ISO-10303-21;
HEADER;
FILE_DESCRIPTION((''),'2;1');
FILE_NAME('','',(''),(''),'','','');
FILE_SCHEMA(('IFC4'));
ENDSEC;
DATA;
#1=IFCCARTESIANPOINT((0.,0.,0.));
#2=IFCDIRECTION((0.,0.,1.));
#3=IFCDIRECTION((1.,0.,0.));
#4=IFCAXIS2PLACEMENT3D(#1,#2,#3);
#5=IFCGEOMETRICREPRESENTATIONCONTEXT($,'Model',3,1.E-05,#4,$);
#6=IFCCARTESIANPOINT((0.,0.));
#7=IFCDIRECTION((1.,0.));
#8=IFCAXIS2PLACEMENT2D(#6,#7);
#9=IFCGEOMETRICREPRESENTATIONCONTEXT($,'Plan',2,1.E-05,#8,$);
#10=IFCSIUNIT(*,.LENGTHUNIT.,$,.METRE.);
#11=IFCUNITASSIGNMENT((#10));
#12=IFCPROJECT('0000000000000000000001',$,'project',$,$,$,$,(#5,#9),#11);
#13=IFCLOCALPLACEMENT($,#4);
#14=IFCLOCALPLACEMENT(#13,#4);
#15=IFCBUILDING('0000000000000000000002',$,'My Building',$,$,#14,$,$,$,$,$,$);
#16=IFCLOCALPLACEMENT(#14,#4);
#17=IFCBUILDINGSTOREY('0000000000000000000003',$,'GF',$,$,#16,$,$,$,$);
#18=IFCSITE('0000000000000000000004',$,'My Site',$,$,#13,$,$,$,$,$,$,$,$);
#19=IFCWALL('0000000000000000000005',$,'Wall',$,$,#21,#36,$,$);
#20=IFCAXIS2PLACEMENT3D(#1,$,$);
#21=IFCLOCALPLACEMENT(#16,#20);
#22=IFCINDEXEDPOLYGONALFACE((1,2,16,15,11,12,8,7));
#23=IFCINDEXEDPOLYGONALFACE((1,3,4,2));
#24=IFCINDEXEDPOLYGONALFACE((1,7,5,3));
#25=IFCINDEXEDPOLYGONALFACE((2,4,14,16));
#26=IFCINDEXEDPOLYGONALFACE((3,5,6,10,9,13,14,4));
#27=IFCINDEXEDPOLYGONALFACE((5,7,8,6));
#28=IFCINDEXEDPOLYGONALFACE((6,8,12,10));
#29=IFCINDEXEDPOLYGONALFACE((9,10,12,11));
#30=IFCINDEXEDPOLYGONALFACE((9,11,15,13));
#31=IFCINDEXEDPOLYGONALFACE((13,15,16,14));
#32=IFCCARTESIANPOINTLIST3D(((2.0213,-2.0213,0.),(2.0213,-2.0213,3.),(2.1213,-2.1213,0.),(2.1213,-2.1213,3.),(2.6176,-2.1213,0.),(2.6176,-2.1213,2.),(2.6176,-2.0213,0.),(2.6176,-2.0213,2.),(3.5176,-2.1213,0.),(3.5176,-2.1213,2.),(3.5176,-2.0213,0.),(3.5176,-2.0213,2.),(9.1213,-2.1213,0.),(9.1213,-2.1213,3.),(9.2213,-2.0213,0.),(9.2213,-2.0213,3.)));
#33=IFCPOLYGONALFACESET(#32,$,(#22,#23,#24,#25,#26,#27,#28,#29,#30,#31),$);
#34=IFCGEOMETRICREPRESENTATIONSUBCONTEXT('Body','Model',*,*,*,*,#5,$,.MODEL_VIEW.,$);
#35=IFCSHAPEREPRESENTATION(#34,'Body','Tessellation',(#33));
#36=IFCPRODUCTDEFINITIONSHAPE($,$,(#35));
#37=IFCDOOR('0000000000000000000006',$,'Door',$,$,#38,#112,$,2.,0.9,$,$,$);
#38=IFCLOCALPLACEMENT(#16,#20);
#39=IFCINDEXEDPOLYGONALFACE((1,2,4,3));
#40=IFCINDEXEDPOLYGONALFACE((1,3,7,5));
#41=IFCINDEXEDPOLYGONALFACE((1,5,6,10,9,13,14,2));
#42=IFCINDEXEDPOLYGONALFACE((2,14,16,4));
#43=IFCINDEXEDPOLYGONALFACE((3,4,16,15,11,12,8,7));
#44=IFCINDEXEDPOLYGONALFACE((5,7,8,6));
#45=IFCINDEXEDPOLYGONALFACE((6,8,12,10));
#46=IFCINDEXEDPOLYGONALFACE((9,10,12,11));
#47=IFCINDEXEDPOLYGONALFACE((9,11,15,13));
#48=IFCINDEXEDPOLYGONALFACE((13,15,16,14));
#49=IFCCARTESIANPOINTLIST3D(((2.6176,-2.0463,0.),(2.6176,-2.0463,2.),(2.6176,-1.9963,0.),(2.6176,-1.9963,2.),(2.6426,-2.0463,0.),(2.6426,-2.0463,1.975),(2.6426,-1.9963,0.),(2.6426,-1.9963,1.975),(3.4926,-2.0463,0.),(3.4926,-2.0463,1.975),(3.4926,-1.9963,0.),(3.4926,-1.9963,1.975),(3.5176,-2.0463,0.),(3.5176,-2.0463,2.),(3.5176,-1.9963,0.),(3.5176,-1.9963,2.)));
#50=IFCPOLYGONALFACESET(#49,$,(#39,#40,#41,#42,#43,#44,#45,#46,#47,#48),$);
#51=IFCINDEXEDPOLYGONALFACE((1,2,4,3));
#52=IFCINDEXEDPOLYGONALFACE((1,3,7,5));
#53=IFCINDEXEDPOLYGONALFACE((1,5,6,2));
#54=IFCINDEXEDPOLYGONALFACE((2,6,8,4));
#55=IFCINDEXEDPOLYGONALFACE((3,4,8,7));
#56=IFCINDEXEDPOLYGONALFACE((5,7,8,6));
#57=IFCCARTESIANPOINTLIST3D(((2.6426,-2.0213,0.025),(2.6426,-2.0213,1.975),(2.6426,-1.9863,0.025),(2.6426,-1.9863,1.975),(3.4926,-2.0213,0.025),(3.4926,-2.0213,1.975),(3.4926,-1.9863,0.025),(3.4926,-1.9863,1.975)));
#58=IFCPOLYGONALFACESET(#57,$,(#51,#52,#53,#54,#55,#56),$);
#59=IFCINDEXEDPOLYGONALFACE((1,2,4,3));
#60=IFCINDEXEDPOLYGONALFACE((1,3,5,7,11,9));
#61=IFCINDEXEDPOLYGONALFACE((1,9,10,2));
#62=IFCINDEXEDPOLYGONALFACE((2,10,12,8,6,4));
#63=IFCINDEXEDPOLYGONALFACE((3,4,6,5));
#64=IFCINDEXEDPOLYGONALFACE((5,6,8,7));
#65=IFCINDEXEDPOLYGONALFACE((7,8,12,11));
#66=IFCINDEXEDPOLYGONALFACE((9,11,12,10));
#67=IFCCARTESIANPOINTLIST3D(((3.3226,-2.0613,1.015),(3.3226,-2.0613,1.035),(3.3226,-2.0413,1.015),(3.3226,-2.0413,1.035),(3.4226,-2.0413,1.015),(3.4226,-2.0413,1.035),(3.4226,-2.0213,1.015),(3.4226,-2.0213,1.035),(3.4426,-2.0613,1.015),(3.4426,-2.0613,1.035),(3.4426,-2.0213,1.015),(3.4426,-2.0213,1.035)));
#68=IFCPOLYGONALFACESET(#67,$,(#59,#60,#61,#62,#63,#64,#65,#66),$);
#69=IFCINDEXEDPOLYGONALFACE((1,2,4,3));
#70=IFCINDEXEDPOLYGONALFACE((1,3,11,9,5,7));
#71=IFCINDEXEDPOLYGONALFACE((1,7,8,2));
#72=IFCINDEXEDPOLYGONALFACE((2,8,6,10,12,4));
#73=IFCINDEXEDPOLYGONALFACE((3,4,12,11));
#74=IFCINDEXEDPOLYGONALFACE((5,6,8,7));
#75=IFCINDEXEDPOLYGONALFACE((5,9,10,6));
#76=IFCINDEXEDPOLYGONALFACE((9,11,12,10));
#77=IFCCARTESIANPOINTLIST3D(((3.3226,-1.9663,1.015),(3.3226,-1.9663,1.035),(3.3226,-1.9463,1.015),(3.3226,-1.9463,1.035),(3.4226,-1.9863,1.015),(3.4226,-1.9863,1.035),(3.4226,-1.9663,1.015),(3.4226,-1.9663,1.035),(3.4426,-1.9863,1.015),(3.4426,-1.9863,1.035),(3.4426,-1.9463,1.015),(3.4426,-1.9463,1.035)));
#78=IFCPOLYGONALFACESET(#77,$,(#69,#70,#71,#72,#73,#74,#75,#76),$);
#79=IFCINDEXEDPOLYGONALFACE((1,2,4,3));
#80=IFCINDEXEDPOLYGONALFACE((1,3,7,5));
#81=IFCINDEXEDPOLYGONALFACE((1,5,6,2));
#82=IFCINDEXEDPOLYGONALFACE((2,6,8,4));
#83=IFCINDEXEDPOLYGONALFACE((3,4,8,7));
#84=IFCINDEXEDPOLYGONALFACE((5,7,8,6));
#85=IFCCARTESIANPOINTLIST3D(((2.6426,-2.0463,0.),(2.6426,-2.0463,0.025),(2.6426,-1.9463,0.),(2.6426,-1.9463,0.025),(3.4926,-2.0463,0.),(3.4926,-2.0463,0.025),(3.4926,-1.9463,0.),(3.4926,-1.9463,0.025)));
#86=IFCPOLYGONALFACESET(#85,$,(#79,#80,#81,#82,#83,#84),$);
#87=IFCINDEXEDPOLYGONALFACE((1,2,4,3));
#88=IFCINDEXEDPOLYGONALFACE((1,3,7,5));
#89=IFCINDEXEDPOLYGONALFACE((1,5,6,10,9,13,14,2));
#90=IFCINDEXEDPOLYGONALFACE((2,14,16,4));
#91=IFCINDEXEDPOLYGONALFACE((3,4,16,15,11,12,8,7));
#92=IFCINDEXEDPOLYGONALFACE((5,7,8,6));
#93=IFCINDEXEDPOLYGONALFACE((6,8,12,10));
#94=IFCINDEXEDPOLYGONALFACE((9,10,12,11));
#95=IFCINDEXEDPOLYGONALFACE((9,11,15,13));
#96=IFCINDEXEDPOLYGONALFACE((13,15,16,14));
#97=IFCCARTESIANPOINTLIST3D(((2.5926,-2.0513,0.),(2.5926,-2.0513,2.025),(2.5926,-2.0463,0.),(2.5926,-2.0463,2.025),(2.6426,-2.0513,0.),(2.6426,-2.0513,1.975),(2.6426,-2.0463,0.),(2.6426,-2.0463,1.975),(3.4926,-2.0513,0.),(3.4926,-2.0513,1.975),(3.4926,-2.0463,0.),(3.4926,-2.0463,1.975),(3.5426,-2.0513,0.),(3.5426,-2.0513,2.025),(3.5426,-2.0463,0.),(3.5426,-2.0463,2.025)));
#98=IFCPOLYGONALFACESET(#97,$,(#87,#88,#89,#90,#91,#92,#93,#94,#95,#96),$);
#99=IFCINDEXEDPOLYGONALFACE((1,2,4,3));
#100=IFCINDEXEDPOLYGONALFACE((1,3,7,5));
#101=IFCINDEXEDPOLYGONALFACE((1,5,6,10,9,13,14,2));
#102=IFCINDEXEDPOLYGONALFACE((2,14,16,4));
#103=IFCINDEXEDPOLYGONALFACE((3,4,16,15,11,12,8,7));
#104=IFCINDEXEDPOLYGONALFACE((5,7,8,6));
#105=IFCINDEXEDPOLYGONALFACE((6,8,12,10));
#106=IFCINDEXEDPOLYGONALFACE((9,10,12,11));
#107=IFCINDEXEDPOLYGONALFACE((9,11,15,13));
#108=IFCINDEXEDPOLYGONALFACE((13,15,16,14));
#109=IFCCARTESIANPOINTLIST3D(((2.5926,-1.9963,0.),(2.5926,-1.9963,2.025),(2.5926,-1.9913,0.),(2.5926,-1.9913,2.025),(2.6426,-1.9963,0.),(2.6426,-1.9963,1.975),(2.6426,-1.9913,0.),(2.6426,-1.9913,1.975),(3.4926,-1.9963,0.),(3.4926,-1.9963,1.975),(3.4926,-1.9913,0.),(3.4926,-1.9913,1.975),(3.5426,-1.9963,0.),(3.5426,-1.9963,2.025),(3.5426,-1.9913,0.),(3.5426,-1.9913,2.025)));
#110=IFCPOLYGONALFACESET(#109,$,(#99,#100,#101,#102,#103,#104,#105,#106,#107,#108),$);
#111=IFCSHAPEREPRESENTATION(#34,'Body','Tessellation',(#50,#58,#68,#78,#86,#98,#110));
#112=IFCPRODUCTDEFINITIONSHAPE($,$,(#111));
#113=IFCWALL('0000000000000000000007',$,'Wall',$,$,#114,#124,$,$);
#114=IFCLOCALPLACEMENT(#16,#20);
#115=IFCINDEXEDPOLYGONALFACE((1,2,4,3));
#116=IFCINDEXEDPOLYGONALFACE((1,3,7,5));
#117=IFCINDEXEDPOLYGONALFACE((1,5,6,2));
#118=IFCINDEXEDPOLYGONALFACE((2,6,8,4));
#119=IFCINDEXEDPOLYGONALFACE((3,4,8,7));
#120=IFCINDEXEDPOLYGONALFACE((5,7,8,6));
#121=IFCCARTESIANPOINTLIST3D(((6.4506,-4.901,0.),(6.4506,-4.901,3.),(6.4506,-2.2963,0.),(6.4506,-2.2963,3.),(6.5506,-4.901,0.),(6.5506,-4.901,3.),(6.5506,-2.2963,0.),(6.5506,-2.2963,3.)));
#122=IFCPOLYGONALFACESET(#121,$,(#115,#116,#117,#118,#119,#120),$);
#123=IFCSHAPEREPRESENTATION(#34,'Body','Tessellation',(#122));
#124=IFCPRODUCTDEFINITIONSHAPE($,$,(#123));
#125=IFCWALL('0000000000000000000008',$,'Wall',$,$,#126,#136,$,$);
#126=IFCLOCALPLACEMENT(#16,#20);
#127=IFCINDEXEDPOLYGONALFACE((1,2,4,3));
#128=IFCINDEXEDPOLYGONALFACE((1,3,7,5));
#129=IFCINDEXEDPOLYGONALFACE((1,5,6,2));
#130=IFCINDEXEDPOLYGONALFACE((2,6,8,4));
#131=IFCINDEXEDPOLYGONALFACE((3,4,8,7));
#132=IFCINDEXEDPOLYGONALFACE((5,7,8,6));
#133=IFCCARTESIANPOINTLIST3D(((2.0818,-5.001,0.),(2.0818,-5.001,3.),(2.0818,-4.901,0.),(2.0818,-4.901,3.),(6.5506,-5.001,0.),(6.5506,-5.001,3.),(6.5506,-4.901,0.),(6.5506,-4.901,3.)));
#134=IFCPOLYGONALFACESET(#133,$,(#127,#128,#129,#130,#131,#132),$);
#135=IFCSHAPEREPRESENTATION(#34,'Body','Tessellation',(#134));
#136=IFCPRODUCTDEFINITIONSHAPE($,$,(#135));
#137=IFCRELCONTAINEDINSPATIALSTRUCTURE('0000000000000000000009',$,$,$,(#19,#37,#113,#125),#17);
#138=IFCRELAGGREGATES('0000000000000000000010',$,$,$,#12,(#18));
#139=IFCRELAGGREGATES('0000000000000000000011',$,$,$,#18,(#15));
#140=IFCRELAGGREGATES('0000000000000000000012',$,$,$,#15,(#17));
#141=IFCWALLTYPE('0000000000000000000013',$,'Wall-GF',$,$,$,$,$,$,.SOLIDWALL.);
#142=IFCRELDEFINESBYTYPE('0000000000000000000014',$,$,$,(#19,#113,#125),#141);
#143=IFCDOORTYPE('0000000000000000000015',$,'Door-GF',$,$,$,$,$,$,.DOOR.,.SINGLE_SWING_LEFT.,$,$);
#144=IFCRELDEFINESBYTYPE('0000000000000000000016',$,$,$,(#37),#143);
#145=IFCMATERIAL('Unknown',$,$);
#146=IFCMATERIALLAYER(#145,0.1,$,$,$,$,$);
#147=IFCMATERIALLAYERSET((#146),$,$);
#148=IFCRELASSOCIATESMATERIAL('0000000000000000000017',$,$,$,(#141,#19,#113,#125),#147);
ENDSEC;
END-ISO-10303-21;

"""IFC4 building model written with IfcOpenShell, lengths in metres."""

from ifc_helpers import new_model, entity, si_unit, frame, origin_with_axes, origin_2d_with_axis, place, context, subcontext, project, spatial, line, indexed_curve, outline, extrude, shape, source, transform, mapped, material, layer, layer_set, layer_usage, type_object, type_shapes, element, fill, save


model = new_model("IFC4")

# Units and contexts
model_context = context("Model", 3, precision=1e-05, world=origin_with_axes())
plan_context = context("Plan", 2, precision=1e-05, world=origin_2d_with_axis())
body_context_1 = subcontext(model_context, "Body", "Model", "MODEL_VIEW")
body_context_2 = subcontext(plan_context, "Body", "Plan", "PLAN_VIEW")
ifc_project = project(units=[si_unit("LENGTHUNIT", "METRE")], contexts=[model_context, plan_context])

# Site, building, storey
site_placement = place(None, origin_with_axes())
site = spatial("IfcSite", under=ifc_project, at=site_placement, Name="My Site")
building_placement = place(site_placement, origin_with_axes())
building = spatial("IfcBuilding", under=site, at=building_placement, Name="My Building")
storey_placement = place(building_placement, origin_with_axes())
storey = spatial("IfcBuildingStorey", under=building, at=storey_placement, Name="GF")

# Shared definitions
ifc_material = material(Name="Unknown")

# Shared definitions
ifc_layer_1 = layer(ifc_material, 0.1)
ifc_layer_set_1 = layer_set([ifc_layer_1])
wall_type = type_object("IfcWallType", Name="Wall-GF", PredefinedType="SOLIDWALL", material=ifc_layer_set_1)

# Shared definitions
shared_shape_1 = source(origin_with_axes(), body_context_1, "Body", "SweptSolid", [
    extrude(outline(indexed_curve([(0.0, 0.0), (0.9, 0.0), (0.9, 2.0), (0.0, 2.0)], segments=[line(1, 2, 3, 4, 1)])), frame((0.0, -0.6, 0.0), z_axis=(0.0, -1.0, 0.0), x_axis=(1.0, 0.0, 0.0)), (0.0, 0.0, -1.0), 1.2),
])
door_type = type_object("IfcDoorType", Name="Door-GF", OperationType="SINGLE_SWING_LEFT", PredefinedType="DOOR")
shared_shape_2 = source(origin_with_axes(), body_context_1, "Body", "SweptSolid", [
    extrude(outline(indexed_curve([(0.0, 0.0), (0.0, 2.0), (0.9, 2.0), (0.9, 0.0), (0.875, 0.0), (0.875, 1.975), (0.025, 1.975), (0.025, 0.0)], segments=[line(1, 2, 3, 4, 5, 6, 7, 8, 1)])), frame((0.0, 0.0, 0.0), z_axis=(0.0, -1.0, 0.0), x_axis=(1.0, 0.0, 0.0)), (0.0, 0.0, -1.0), 0.05),
    extrude(outline(indexed_curve([(0.0, 0.0), (0.85, 0.0), (0.85, 0.035), (0.0, 0.035)], segments=[line(1, 2, 3, 4, 1)])), frame((0.025, 0.025, 0.025), z_axis=(0.0, 0.0, 1.0), x_axis=(1.0, 0.0, 0.0)), (0.0, 0.0, 1.0), 1.95),
    extrude(outline(indexed_curve([(0.0, 0.0), (0.0, -0.04), (-0.12, -0.04), (-0.12, -0.02), (-0.02, -0.02), (-0.02, 0.0)], segments=[line(1, 2, 3, 4, 5, 6, 1)])), frame((0.825, 0.025, 1.015), z_axis=(0.0, 0.0, 1.0), x_axis=(1.0, 0.0, 0.0)), (0.0, 0.0, 1.0), 0.02),
    extrude(outline(indexed_curve([(0.0, 0.0), (0.0, 0.04), (-0.12, 0.04), (-0.12, 0.02), (-0.02, 0.02), (-0.02, 0.0)], segments=[line(1, 2, 3, 4, 5, 6, 1)])), frame((0.825, 0.06, 1.015), z_axis=(0.0, 0.0, 1.0), x_axis=(1.0, 0.0, 0.0)), (0.0, 0.0, 1.0), 0.02),
    extrude(outline(indexed_curve([(0.0, 0.0), (0.85, 0.0), (0.85, 0.1), (0.0, 0.1)], segments=[line(1, 2, 3, 4, 1)])), frame((0.025, 0.0, 0.0), z_axis=(0.0, 0.0, 1.0), x_axis=(1.0, 0.0, 0.0)), (0.0, 0.0, 1.0), 0.025),
    extrude(outline(indexed_curve([(0.0, 0.0), (0.0, 2.025), (0.95, 2.025), (0.95, 0.0), (0.9, 0.0), (0.9, 1.975), (0.05, 1.975), (0.05, 0.0)], segments=[line(1, 2, 3, 4, 5, 6, 7, 8, 1)])), frame((-0.025, -0.005, 0.0), z_axis=(0.0, -1.0, 0.0), x_axis=(1.0, 0.0, 0.0)), (0.0, 0.0, -1.0), 0.005),
    extrude(outline(indexed_curve([(0.0, 0.0), (0.0, 2.025), (0.95, 2.025), (0.95, 0.0), (0.9, 0.0), (0.9, 1.975), (0.05, 1.975), (0.05, 0.0)], segments=[line(1, 2, 3, 4, 5, 6, 7, 8, 1)])), frame((-0.025, 0.05, 0.0), z_axis=(0.0, -1.0, 0.0), x_axis=(1.0, 0.0, 0.0)), (0.0, 0.0, -1.0), 0.005),
])
shared_shape_3 = source(origin_with_axes(), body_context_2, "Body", "Curve2D", [
    entity("IfcIndexedPolyCurve", entity("IfcCartesianPointList2D", [[0.0, 0.0], [0.025, 0.0], [0.025, 0.05], [0.0, 0.05]]), [entity("IfcLineIndex", [1, 2, 3, 4, 1])]),
    entity("IfcIndexedPolyCurve", entity("IfcCartesianPointList2D", [[0.9, 0.0], [0.875, 0.0], [0.875, 0.05], [0.9, 0.05]]), [entity("IfcLineIndex", [1, 2, 3, 4, 1])]),
    entity("IfcIndexedPolyCurve", entity("IfcCartesianPointList2D", [[0.025, 0.05], [0.025, -0.8], [0.06, -0.8]])),
    entity("IfcTrimmedCurve", entity("IfcEllipse", entity("IfcAxis2Placement2D", entity("IfcCartesianPoint", [0.06, 0.05]), entity("IfcDirection", [1.0, 0.0])), 0.815, 0.85), [entity("IfcCartesianPoint", [0.06, -0.8])], [entity("IfcCartesianPoint", [0.06, 0.9])], True, "CARTESIAN"),
    entity("IfcIndexedPolyCurve", entity("IfcCartesianPointList2D", [[0.025, 0.05], [0.06, 0.05], [0.06, 0.9], [0.025, 0.9]]), [entity("IfcLineIndex", [1, 2, 3, 4, 1])]),
])
type_shapes(door_type, [shared_shape_2, shared_shape_3])

# Wall, opening, door
ifc_layer_usage_1 = layer_usage(ifc_layer_set_1, "AXIS2", "POSITIVE", 0.0)
wall_1_placement = place(storey_placement, frame((2.1213, -2.1213, 0.0), z_axis=(0.0, 0.0, 1.0), x_axis=(1.0, 0.0, 0.0)))
wall_1 = element("IfcWall", 1, at=wall_1_placement, inside=storey, type_object=wall_type, material=ifc_layer_usage_1, Name="Wall", context=body_context_1, shape_type="SweptSolid", body=[
    extrude(outline(indexed_curve([(0.0, 0.0), (-0.1, 0.1), (7.1, 0.1), (7.0, 0.0)], segments=[line(1, 2, 3, 4, 1)])), origin_with_axes(), (0.0, 0.0, 1.0), 3.0),
])
opening_1_placement = place(wall_1_placement, frame((1.3963, 0.1, 0.0), z_axis=(0.0, 0.0, 1.0), x_axis=(-1.0, 0.0, 0.0)))
opening_1 = element("IfcOpeningElement", 2, at=opening_1_placement, cuts=wall_1, PredefinedType="OPENING", context=body_context_1, shape_type="MappedRepresentation", body=[
    mapped(shared_shape_1, transform((0.0, 0.0, 0.0), x_axis=(1.0, 0.0, 0.0), y_axis=(0.0, 1.0, 0.0), z_axis=(0.0, 0.0, 1.0), scale=1.0)),
])
door_1_placement = place(opening_1_placement, frame((0.9, 0.025, 0.0), z_axis=(0.0, 0.0, 1.0), x_axis=(-1.0, 0.0, 0.0)))
door_1 = element("IfcDoor", 3, at=door_1_placement, inside=storey, type_object=door_type, Name="Door", OverallHeight=2.0, OverallWidth=0.9, shapes=[
    shape(body_context_1, "Body", "MappedRepresentation", [mapped(shared_shape_2, transform((0.0, 0.0, 0.0), x_axis=(1.0, 0.0, 0.0), y_axis=(0.0, 1.0, 0.0), z_axis=(0.0, 0.0, 1.0), scale=1.0))]),
    shape(body_context_2, "Body", "MappedRepresentation", [mapped(shared_shape_3, transform((0.0, 0.0, 0.0), x_axis=(1.0, 0.0, 0.0), y_axis=(0.0, 1.0, 0.0), z_axis=(0.0, 0.0, 1.0), scale=1.0))]),
])
fill(opening_1, door_1)

# Walls
ifc_layer_usage_2 = layer_usage(ifc_layer_set_1, "AXIS2", "POSITIVE", 0.0)
wall_2_placement = place(storey_placement, frame((6.4506, -2.2963, 0.0), z_axis=(0.0, 0.0, 1.0), x_axis=(0.0, -1.0, 0.0)))
element("IfcWall", 4, at=wall_2_placement, inside=storey, type_object=wall_type, material=ifc_layer_usage_2, Name="Wall", context=body_context_1, shape_type="SweptSolid", body=[
    extrude(outline(indexed_curve([(0.0, 0.0), (0.0, 0.1), (2.6047, 0.1), (2.6047, 0.0)], segments=[line(1, 2, 3, 4, 1)])), origin_with_axes(), (0.0, 0.0, 1.0), 3.0),
])
ifc_layer_usage_3 = layer_usage(ifc_layer_set_1, "AXIS2", "POSITIVE", 0.0)
wall_3_placement = place(storey_placement, frame((6.5506, -4.901, 0.0), z_axis=(0.0, 0.0, 1.0), x_axis=(-1.0, 0.0, 0.0)))
element("IfcWall", 5, at=wall_3_placement, inside=storey, type_object=wall_type, material=ifc_layer_usage_3, Name="Wall", context=body_context_1, shape_type="SweptSolid", body=[
    extrude(outline(indexed_curve([(0.0, 0.0), (0.0, 0.1), (4.4688, 0.1), (4.4688, 0.0)], segments=[line(1, 2, 3, 4, 1)])), origin_with_axes(), (0.0, 0.0, 1.0), 3.0),
])

save(model, "model.ifc")
